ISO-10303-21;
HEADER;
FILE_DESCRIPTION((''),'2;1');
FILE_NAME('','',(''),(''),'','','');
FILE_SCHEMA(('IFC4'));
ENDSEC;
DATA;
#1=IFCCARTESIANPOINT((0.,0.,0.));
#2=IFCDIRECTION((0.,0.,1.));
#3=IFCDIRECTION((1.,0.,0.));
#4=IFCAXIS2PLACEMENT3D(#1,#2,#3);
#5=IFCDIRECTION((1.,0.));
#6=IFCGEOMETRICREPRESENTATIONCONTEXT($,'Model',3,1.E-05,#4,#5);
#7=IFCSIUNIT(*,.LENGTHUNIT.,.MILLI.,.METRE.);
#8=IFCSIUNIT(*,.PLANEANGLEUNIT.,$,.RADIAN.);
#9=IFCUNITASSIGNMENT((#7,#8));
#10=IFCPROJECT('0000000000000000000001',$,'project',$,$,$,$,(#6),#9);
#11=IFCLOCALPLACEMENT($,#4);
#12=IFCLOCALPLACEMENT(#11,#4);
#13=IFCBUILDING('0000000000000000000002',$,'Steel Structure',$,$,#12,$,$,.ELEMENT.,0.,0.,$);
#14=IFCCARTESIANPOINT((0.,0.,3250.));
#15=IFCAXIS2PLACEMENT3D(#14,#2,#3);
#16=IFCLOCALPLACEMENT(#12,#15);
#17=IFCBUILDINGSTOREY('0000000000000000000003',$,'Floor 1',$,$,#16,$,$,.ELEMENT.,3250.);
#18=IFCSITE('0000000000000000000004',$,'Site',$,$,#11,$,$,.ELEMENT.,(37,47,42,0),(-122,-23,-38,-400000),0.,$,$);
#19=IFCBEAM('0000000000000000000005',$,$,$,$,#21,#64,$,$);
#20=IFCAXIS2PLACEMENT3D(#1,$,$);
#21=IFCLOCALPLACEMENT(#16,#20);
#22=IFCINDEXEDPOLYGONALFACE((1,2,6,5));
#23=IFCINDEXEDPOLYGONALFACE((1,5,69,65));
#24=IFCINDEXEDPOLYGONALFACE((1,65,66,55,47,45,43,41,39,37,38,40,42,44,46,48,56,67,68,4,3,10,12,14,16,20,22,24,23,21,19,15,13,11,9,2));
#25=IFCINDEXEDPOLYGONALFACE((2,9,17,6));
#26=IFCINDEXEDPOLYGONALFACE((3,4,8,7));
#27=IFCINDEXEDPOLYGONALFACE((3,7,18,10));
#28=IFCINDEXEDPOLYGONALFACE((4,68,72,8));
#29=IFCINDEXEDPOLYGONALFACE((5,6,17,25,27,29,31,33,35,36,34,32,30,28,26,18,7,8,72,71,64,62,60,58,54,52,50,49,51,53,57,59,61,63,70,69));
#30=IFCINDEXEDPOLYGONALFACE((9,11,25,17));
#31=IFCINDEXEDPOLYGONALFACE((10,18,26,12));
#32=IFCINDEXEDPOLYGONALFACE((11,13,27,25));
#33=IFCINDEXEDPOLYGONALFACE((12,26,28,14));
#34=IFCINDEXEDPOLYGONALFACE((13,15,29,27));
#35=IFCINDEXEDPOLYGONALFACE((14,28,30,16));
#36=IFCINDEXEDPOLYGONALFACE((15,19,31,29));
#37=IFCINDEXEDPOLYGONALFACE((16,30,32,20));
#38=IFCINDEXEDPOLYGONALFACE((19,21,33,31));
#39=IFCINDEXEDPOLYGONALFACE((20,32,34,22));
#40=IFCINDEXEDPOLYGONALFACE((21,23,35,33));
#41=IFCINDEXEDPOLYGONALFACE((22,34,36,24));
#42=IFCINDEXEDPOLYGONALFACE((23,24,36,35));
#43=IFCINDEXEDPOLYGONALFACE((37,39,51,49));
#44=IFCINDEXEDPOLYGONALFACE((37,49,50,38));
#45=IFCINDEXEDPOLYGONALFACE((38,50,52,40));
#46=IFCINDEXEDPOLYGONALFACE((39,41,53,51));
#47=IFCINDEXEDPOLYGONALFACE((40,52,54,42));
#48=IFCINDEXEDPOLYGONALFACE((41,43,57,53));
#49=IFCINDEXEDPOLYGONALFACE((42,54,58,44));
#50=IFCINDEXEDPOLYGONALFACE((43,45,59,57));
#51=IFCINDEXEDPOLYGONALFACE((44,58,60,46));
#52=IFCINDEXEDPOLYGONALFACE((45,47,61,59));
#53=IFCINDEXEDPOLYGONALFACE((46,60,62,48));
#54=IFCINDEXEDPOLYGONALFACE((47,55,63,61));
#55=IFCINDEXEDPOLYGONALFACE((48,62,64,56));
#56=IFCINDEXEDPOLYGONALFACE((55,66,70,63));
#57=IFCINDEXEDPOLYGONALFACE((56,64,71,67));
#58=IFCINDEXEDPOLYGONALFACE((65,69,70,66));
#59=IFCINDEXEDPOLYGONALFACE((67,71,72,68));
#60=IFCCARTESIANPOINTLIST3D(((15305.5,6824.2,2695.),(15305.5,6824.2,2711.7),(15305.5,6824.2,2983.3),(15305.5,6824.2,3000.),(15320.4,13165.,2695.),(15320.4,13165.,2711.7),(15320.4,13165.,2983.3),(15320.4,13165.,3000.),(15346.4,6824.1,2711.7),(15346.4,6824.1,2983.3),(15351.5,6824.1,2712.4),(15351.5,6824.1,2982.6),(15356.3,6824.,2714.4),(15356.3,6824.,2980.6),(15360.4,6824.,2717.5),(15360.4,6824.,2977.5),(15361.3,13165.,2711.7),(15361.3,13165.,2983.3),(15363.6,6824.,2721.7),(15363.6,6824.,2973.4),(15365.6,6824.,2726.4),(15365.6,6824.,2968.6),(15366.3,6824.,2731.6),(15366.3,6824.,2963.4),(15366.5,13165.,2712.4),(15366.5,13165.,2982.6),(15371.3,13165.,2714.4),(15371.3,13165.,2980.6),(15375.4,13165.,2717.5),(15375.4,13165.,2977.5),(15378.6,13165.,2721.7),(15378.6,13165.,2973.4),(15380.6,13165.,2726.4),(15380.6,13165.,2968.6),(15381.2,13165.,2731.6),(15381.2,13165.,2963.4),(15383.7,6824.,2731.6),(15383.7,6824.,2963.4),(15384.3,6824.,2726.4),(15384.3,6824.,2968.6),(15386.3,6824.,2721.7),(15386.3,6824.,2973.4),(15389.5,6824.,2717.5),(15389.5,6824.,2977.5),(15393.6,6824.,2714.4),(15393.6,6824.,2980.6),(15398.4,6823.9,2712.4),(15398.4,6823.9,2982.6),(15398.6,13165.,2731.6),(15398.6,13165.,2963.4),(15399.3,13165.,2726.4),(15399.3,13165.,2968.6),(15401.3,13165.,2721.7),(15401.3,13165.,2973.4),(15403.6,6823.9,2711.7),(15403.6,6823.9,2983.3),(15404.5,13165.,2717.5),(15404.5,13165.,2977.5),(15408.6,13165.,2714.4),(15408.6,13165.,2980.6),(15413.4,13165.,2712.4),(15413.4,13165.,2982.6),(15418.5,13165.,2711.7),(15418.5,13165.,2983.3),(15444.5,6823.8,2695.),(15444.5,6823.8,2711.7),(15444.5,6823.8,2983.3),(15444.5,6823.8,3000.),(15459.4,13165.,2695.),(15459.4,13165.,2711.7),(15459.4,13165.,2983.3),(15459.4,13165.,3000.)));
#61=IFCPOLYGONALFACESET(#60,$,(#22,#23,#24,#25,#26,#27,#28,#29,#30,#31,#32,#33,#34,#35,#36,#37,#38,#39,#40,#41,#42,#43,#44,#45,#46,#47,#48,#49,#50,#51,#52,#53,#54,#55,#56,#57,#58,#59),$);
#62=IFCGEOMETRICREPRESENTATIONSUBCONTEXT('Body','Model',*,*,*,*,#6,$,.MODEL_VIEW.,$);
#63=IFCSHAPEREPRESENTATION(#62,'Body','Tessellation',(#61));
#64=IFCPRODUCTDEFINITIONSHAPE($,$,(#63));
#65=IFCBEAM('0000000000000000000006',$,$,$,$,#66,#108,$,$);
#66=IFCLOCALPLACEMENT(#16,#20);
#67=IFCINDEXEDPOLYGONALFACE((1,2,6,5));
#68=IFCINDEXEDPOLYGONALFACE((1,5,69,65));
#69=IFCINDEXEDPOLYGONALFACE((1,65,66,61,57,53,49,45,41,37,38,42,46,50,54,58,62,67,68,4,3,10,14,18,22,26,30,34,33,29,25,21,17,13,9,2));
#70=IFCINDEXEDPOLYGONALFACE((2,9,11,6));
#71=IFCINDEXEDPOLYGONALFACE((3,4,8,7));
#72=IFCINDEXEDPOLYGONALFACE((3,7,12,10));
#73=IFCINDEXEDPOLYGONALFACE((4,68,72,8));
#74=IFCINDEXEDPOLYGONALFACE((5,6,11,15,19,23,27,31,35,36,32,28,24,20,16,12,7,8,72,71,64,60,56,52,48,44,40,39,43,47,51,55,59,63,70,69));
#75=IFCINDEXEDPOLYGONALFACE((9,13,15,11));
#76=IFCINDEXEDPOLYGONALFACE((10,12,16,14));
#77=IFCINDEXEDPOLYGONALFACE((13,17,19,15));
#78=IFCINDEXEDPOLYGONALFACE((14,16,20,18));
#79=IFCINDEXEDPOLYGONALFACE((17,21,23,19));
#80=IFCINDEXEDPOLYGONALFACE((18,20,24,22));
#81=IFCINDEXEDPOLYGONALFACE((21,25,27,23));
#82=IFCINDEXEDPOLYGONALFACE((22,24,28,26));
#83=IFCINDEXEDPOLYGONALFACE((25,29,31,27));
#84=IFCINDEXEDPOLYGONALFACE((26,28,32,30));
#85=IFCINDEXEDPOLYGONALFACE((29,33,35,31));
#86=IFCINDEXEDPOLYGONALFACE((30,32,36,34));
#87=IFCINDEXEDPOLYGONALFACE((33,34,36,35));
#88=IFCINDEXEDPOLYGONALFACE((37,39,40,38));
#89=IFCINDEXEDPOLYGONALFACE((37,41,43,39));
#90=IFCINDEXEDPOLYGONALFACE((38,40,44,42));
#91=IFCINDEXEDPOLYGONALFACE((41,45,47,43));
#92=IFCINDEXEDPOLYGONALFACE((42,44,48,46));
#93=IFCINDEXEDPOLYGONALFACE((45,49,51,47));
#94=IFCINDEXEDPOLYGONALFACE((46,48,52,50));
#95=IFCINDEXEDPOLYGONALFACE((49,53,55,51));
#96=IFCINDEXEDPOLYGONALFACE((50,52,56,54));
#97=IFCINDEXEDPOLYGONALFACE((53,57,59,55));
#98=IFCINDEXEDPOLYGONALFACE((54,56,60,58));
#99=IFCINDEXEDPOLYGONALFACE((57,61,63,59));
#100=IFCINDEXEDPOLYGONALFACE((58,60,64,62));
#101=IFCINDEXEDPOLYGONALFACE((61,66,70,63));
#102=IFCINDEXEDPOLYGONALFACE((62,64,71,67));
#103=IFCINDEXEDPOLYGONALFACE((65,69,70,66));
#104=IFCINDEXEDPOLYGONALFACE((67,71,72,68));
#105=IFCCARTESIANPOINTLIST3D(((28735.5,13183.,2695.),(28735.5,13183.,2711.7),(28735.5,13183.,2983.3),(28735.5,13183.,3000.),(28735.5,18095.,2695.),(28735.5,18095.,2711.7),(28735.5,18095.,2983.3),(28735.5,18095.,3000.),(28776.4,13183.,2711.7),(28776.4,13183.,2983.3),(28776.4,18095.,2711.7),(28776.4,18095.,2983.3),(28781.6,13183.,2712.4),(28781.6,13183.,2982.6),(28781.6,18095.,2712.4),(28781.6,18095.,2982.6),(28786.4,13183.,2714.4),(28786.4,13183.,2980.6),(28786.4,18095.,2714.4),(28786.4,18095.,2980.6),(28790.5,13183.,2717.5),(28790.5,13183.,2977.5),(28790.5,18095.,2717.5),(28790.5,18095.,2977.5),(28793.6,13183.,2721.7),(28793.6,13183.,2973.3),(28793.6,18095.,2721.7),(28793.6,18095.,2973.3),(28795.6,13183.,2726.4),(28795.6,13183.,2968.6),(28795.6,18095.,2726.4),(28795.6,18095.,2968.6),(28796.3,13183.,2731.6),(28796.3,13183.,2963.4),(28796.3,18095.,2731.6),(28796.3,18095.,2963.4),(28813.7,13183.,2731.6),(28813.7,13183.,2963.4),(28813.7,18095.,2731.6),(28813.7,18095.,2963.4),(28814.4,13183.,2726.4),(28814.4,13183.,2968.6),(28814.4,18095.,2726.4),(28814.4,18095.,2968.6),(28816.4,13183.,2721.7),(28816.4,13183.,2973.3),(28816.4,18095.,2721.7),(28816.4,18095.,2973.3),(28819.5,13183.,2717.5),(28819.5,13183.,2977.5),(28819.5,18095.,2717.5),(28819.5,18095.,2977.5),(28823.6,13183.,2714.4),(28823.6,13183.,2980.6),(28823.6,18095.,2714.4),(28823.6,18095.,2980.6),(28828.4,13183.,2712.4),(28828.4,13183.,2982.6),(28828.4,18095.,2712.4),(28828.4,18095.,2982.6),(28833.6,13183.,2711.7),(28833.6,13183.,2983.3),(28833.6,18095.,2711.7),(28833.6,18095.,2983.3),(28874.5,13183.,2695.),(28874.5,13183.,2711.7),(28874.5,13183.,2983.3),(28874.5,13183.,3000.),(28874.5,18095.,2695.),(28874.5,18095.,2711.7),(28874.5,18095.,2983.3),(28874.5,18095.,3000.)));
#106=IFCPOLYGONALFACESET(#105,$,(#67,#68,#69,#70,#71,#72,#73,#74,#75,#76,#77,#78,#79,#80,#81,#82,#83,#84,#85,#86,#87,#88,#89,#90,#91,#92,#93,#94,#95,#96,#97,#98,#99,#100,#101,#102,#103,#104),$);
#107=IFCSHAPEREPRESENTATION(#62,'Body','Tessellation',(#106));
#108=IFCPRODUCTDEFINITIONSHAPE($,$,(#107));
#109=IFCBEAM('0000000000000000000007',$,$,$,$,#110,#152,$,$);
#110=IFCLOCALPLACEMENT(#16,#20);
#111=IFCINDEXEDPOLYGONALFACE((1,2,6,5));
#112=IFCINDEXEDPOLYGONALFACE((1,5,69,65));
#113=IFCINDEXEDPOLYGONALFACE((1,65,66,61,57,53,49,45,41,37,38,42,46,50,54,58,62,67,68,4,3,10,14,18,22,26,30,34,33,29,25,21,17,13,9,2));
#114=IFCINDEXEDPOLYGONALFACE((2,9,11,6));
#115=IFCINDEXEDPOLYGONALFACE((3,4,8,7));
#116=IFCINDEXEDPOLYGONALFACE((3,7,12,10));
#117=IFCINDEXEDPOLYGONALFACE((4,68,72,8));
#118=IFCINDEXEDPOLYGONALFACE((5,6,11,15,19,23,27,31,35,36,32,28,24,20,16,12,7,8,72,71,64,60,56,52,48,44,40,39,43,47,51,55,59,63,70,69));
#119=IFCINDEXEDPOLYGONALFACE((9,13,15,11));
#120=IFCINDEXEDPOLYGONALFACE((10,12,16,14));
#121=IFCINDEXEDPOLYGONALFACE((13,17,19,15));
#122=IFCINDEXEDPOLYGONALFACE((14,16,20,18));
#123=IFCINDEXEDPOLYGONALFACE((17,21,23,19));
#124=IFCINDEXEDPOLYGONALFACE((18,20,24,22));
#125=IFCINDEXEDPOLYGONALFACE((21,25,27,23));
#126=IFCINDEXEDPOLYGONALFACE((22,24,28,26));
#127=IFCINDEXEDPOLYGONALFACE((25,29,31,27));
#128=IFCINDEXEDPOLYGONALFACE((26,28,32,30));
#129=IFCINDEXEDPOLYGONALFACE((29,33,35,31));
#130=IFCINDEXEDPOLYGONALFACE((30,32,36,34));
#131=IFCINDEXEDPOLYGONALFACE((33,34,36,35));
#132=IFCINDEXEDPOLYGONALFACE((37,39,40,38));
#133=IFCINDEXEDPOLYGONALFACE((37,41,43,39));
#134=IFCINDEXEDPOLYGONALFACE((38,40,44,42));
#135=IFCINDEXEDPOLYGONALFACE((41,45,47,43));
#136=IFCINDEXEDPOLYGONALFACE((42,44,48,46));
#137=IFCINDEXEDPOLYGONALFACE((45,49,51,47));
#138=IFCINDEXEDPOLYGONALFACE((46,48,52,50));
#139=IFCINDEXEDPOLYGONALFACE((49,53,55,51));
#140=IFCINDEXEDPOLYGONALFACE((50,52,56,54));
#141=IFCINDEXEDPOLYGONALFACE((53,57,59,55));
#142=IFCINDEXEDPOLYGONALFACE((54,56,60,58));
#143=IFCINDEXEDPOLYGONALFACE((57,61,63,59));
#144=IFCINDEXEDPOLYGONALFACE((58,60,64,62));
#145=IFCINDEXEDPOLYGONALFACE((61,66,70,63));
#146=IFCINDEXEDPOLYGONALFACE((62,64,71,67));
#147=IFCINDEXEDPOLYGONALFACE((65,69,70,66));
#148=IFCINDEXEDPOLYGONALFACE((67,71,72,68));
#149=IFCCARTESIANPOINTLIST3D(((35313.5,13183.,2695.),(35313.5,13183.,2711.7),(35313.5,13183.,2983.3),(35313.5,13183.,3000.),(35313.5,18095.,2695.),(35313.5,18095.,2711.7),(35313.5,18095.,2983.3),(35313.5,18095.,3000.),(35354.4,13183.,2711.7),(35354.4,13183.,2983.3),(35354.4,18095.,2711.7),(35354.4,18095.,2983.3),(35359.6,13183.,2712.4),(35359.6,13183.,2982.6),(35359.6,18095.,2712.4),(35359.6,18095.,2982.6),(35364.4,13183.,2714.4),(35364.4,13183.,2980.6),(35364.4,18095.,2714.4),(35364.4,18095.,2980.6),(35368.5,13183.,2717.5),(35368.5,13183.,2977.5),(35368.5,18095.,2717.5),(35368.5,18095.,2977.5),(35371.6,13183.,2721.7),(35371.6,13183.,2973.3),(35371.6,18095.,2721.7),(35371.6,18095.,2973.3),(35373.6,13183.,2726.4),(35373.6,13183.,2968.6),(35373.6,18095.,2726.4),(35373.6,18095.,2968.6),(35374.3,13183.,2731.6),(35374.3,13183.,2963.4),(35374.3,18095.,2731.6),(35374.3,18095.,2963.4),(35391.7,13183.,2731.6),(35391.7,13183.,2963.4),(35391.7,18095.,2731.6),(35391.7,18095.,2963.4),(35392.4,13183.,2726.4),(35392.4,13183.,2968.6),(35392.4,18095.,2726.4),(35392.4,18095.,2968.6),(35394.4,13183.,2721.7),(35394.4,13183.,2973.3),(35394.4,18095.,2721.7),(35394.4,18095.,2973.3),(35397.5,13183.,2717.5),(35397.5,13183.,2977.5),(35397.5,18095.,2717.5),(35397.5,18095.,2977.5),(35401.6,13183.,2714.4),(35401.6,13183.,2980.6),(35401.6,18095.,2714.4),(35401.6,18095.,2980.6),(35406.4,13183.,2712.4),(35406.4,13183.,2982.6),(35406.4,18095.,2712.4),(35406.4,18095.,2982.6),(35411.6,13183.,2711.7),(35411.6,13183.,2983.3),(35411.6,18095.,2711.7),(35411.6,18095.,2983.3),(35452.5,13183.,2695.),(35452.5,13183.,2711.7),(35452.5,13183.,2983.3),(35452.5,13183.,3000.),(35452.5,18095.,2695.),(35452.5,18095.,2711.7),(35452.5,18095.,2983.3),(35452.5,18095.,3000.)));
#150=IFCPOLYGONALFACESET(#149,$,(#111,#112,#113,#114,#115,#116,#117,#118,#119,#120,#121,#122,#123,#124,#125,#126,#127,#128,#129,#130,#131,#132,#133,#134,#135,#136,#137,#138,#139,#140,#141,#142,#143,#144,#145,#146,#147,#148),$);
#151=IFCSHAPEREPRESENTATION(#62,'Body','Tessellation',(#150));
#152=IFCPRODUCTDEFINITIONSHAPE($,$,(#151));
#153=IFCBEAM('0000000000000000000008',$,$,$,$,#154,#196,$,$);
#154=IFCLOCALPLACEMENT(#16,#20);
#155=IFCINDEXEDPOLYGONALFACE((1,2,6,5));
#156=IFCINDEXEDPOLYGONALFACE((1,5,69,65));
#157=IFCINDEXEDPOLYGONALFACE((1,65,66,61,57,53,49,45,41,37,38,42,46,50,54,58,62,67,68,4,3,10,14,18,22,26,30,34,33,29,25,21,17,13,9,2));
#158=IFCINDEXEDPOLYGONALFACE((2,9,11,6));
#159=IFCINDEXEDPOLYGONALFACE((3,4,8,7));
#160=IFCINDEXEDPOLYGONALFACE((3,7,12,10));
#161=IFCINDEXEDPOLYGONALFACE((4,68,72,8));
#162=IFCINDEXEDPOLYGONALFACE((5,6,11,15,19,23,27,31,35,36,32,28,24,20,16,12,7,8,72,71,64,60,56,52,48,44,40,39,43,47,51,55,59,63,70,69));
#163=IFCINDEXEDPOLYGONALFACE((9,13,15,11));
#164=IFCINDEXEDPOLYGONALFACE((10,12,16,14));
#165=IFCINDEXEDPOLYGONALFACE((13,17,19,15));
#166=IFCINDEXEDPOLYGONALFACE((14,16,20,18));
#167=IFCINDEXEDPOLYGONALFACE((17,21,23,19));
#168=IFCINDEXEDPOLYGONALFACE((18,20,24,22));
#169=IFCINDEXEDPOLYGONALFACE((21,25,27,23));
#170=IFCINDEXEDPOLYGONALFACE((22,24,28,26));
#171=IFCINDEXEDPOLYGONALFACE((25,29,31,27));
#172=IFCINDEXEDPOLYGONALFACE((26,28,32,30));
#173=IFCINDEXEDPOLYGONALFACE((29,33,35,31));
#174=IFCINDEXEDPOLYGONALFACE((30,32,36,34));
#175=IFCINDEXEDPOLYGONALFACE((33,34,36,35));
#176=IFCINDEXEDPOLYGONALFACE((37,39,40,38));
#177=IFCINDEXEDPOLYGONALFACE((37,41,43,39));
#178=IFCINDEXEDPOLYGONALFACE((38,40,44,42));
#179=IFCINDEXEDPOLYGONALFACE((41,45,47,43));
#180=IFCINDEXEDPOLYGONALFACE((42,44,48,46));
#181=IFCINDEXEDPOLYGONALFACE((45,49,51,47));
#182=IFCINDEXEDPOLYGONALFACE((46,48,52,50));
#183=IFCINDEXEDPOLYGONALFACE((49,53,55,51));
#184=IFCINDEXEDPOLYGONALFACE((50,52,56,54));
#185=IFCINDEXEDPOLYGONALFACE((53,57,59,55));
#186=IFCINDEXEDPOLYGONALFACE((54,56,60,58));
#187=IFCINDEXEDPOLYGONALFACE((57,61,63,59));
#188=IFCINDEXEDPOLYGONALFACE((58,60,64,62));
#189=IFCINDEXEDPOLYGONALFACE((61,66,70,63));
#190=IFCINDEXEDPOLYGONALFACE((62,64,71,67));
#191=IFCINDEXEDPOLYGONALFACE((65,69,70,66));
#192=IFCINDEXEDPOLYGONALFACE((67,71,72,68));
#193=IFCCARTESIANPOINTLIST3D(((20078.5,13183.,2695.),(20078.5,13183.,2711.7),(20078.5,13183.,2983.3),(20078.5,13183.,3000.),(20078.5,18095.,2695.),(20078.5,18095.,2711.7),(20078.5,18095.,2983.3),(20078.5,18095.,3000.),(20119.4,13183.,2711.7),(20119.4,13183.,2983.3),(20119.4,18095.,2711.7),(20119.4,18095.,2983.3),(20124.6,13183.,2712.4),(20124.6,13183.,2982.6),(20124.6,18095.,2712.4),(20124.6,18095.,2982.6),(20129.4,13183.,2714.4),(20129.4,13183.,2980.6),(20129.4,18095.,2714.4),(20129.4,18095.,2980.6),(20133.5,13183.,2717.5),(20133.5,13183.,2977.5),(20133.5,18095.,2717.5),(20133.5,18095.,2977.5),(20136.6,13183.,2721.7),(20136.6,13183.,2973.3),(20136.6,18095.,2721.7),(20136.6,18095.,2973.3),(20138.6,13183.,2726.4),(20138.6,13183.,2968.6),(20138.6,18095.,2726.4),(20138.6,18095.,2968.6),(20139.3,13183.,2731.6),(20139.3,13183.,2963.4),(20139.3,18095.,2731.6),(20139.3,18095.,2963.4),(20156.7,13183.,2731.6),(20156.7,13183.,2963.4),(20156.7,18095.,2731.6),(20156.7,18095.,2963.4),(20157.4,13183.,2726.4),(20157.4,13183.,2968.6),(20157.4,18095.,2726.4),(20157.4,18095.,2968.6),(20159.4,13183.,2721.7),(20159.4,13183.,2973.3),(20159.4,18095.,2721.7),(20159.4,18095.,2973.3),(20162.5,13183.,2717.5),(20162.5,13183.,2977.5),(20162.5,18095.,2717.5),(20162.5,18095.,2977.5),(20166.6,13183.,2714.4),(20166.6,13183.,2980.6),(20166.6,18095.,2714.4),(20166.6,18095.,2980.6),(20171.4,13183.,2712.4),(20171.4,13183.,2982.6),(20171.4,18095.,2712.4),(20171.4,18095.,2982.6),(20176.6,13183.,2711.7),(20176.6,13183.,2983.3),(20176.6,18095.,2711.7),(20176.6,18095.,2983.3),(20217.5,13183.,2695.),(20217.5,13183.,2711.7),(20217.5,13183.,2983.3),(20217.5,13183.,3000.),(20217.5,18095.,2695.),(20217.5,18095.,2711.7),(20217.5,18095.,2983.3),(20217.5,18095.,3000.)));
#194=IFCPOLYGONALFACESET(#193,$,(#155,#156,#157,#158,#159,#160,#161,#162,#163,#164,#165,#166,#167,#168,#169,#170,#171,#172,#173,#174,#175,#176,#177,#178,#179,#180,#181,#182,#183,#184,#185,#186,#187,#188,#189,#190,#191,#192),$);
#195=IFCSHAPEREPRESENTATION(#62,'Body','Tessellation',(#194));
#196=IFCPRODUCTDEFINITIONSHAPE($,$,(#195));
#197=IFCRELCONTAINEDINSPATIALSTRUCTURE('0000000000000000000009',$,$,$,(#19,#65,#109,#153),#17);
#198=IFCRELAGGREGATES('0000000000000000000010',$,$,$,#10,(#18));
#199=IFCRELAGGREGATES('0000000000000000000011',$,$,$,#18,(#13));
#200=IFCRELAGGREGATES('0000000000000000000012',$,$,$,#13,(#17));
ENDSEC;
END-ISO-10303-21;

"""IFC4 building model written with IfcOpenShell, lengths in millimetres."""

from ifc_helpers import new_model, si_unit, direction, frame, origin_with_axes, origin_2d_with_axis, place, context, subcontext, project, spatial, polyline, i_section, extrude, clip, bounded_halfspace, element, save


model = new_model("IFC4")

# Units and contexts
model_context = context("Model", 3, precision=1e-05, world=origin_with_axes(), true_north=direction((1.0, 0.0)))
body_context = subcontext(model_context, "Body", "Model", "MODEL_VIEW")
ifc_project = project(units=[si_unit("LENGTHUNIT", "METRE", prefix="MILLI"), si_unit("PLANEANGLEUNIT", "RADIAN")], contexts=[model_context])

# Site, building, storey
site_placement = place(None, origin_with_axes())
site = spatial("IfcSite", under=ifc_project, at=site_placement, Name="Site", CompositionType="ELEMENT", RefLatitude=(37, 47, 42, 0), RefLongitude=(-122, -23, -38, -400000), RefElevation=0.0)
building_placement = place(site_placement, origin_with_axes())
building = spatial("IfcBuilding", under=site, at=building_placement, Name="Steel Structure", CompositionType="ELEMENT", ElevationOfRefHeight=0.0, ElevationOfTerrain=0.0)
storey_placement = place(building_placement, frame((0.0, 0.0, 3250.0), z_axis=(0.0, 0.0, 1.0), x_axis=(1.0, 0.0, 0.0)))
storey = spatial("IfcBuildingStorey", under=building, at=storey_placement, Name="Floor 1", CompositionType="ELEMENT", Elevation=3250.0)

# Beams
beam_1_placement = place(storey_placement, frame((15389.9, 13165.2, 2695.0), z_axis=(-0.002362, -0.999997, 0.0), x_axis=(0.999997, -0.002362, 0.0)))
element("IfcBeam", 1, at=beam_1_placement, inside=storey, context=body_context, shape_type="Clipping", body=[
    clip(extrude(i_section(OverallWidth=139.0, OverallDepth=305.0, WebThickness=17.4, FlangeThickness=16.7, FilletRadius=19.9, at=origin_2d_with_axis()), frame((0.0, 152.5, 0.0), z_axis=(0.0, 0.0, 1.0), x_axis=(1.0, 0.0, 0.0)), (0.0, 0.0, 1.0), 6341.2), bounded_halfspace(frame((-15389.9, -5945.0, 36.5), z_axis=(-0.002362, 0.0, -0.999997), x_axis=(-0.999997, 0.0, 0.002362)), False, frame((0.0, 152.5, 0.0), z_axis=(0.0, 0.0, 1.0), x_axis=(1.0, 0.0, 0.0)), polyline([(69.5, 152.5), (69.5, 135.8), (28.6, 135.8), (8.7, 115.9), (8.7, -115.9), (28.6, -135.8), (69.5, -135.8), (69.5, -152.5), (-69.5, -152.5), (-69.5, -135.8), (-28.6, -135.8), (-8.7, -115.9), (-8.7, 115.9), (-28.6, 135.8), (-69.5, 135.8), (-69.5, 152.5), (69.5, 152.5)]))),
])
beam_2_placement = place(storey_placement, frame((28805.0, 13183.0, 2695.0), z_axis=(0.0, 1.0, 0.0), x_axis=(-1.0, 0.0, 0.0)))
element("IfcBeam", 2, at=beam_2_placement, inside=storey, context=body_context, shape_type="SweptSolid", body=[
    extrude(i_section(OverallWidth=139.0, OverallDepth=305.0, WebThickness=17.4, FlangeThickness=16.7, FilletRadius=19.9, at=origin_2d_with_axis()), frame((0.0, 152.5, 0.0), z_axis=(0.0, 0.0, 1.0), x_axis=(1.0, 0.0, 0.0)), (0.0, 0.0, 1.0), 4912.0),
])
for number, where, z_axis, x_axis in (
    (3, (35383.0, 13183.0, 2695.0), (0.0, 1.0, 0.0), (-1.0, 0.0, 0.0)),
    (4, (20148.0, 13183.0, 2695.0), (0.0, 1.0, 0.0), (-1.0, 0.0, 0.0)),
):
    element("IfcBeam", number, at=place(storey_placement, frame(where, z_axis=z_axis, x_axis=x_axis)), inside=storey, context=body_context, shape_type="SweptSolid", body=[
        extrude(i_section(OverallWidth=139.0, OverallDepth=305.0, WebThickness=17.4, FlangeThickness=16.7, FilletRadius=19.9, at=origin_2d_with_axis()), frame((0.0, 152.5, 0.0), z_axis=(0.0, 0.0, 1.0), x_axis=(1.0, 0.0, 0.0)), (0.0, 0.0, 1.0), 4912.0),
    ])

save(model, "model.ifc")
